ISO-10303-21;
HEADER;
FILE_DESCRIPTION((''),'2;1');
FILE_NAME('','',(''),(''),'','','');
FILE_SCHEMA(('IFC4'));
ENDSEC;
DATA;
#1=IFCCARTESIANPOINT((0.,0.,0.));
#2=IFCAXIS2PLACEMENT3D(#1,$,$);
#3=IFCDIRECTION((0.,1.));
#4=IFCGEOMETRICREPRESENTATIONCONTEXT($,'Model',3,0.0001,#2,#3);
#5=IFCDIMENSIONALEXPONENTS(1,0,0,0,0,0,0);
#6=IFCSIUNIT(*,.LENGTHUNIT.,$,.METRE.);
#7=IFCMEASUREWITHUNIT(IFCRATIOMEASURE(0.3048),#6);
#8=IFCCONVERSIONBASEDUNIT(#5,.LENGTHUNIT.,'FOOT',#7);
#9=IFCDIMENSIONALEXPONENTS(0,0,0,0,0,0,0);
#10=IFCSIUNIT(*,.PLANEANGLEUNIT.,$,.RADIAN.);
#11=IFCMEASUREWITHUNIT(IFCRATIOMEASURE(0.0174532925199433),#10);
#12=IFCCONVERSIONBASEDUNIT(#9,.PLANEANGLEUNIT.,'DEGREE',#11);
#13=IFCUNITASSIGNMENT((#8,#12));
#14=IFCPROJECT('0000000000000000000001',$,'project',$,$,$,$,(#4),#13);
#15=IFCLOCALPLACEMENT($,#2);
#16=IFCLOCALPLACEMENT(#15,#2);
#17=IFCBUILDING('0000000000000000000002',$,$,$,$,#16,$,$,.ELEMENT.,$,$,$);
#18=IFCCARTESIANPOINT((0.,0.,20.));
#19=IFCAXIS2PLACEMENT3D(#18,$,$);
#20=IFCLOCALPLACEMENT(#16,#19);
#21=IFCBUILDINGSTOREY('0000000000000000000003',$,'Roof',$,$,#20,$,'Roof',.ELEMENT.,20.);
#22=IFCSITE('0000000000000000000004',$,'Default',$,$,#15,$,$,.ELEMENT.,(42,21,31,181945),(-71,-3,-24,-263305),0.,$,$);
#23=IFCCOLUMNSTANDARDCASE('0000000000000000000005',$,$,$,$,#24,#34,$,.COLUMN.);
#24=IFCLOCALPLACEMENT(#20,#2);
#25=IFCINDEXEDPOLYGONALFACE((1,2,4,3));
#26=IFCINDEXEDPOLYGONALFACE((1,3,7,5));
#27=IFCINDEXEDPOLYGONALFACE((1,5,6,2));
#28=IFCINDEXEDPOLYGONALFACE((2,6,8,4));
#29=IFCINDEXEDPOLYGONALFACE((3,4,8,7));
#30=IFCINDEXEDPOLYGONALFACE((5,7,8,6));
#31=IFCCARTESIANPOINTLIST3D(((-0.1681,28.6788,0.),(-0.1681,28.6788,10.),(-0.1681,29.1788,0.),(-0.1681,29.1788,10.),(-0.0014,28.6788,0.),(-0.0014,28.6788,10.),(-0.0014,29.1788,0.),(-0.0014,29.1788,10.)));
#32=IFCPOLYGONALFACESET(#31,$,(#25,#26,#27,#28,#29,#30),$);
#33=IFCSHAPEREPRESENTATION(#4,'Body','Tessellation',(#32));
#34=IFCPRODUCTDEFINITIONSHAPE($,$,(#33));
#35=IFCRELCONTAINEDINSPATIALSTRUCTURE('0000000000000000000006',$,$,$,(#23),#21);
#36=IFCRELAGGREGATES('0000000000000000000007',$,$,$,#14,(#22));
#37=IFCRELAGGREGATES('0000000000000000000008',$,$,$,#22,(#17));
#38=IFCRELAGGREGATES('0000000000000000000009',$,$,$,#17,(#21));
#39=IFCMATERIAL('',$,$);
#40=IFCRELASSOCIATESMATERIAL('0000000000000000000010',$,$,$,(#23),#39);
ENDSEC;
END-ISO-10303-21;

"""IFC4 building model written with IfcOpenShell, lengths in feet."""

from ifc_helpers import new_model, entity, si_unit, converted_unit, direction, frame, origin, place, context, project, spatial, rectangle, extrude, material, element, save


model = new_model("IFC4")

# Units and contexts
model_context = context("Model", 3, precision=0.0001, world=origin(), true_north=direction((0.0, 1.0)))
ifc_project = project(units=[converted_unit("LENGTHUNIT", "FOOT", entity("IfcRatioMeasure", 0.3048), si_unit("LENGTHUNIT", "METRE"), dimensions=[1, 0, 0, 0, 0, 0, 0]), converted_unit("PLANEANGLEUNIT", "DEGREE", entity("IfcRatioMeasure", 0.0174532925199433), si_unit("PLANEANGLEUNIT", "RADIAN"), dimensions=[0, 0, 0, 0, 0, 0, 0])], contexts=[model_context])

# Site, building, storey
site_placement = place(None, origin())
site = spatial("IfcSite", under=ifc_project, at=site_placement, Name="Default", CompositionType="ELEMENT", RefLatitude=(42, 21, 31, 181945), RefLongitude=(-71, -3, -24, -263305), RefElevation=0.0)
building_placement = place(site_placement, origin())
building = spatial("IfcBuilding", under=site, at=building_placement, CompositionType="ELEMENT")
storey_placement = place(building_placement, frame((0.0, 0.0, 20.0)))
storey = spatial("IfcBuildingStorey", under=building, at=storey_placement, Name="Roof", LongName="Roof", CompositionType="ELEMENT", Elevation=20.0)

# Column
ifc_material_1 = material(Name="")
wall_placement = place(storey_placement, frame((-0.1681, 28.9288, 0.0)))
column_placement = place(wall_placement, frame((0.0833, 0.0, 0.0), z_axis=(0.0, 0.0, 1.0), x_axis=(1.0, 0.0, 0.0)))
element("IfcColumnStandardCase", 1, at=column_placement, inside=storey, material=ifc_material_1, PredefinedType="COLUMN", context=model_context, shape_type="SweptSolid", body=[
    extrude(rectangle(XDim=0.1667, YDim=0.5), origin(), (0.0, 0.0, 1.0), 10.0),
])

save(model, "model.ifc")
